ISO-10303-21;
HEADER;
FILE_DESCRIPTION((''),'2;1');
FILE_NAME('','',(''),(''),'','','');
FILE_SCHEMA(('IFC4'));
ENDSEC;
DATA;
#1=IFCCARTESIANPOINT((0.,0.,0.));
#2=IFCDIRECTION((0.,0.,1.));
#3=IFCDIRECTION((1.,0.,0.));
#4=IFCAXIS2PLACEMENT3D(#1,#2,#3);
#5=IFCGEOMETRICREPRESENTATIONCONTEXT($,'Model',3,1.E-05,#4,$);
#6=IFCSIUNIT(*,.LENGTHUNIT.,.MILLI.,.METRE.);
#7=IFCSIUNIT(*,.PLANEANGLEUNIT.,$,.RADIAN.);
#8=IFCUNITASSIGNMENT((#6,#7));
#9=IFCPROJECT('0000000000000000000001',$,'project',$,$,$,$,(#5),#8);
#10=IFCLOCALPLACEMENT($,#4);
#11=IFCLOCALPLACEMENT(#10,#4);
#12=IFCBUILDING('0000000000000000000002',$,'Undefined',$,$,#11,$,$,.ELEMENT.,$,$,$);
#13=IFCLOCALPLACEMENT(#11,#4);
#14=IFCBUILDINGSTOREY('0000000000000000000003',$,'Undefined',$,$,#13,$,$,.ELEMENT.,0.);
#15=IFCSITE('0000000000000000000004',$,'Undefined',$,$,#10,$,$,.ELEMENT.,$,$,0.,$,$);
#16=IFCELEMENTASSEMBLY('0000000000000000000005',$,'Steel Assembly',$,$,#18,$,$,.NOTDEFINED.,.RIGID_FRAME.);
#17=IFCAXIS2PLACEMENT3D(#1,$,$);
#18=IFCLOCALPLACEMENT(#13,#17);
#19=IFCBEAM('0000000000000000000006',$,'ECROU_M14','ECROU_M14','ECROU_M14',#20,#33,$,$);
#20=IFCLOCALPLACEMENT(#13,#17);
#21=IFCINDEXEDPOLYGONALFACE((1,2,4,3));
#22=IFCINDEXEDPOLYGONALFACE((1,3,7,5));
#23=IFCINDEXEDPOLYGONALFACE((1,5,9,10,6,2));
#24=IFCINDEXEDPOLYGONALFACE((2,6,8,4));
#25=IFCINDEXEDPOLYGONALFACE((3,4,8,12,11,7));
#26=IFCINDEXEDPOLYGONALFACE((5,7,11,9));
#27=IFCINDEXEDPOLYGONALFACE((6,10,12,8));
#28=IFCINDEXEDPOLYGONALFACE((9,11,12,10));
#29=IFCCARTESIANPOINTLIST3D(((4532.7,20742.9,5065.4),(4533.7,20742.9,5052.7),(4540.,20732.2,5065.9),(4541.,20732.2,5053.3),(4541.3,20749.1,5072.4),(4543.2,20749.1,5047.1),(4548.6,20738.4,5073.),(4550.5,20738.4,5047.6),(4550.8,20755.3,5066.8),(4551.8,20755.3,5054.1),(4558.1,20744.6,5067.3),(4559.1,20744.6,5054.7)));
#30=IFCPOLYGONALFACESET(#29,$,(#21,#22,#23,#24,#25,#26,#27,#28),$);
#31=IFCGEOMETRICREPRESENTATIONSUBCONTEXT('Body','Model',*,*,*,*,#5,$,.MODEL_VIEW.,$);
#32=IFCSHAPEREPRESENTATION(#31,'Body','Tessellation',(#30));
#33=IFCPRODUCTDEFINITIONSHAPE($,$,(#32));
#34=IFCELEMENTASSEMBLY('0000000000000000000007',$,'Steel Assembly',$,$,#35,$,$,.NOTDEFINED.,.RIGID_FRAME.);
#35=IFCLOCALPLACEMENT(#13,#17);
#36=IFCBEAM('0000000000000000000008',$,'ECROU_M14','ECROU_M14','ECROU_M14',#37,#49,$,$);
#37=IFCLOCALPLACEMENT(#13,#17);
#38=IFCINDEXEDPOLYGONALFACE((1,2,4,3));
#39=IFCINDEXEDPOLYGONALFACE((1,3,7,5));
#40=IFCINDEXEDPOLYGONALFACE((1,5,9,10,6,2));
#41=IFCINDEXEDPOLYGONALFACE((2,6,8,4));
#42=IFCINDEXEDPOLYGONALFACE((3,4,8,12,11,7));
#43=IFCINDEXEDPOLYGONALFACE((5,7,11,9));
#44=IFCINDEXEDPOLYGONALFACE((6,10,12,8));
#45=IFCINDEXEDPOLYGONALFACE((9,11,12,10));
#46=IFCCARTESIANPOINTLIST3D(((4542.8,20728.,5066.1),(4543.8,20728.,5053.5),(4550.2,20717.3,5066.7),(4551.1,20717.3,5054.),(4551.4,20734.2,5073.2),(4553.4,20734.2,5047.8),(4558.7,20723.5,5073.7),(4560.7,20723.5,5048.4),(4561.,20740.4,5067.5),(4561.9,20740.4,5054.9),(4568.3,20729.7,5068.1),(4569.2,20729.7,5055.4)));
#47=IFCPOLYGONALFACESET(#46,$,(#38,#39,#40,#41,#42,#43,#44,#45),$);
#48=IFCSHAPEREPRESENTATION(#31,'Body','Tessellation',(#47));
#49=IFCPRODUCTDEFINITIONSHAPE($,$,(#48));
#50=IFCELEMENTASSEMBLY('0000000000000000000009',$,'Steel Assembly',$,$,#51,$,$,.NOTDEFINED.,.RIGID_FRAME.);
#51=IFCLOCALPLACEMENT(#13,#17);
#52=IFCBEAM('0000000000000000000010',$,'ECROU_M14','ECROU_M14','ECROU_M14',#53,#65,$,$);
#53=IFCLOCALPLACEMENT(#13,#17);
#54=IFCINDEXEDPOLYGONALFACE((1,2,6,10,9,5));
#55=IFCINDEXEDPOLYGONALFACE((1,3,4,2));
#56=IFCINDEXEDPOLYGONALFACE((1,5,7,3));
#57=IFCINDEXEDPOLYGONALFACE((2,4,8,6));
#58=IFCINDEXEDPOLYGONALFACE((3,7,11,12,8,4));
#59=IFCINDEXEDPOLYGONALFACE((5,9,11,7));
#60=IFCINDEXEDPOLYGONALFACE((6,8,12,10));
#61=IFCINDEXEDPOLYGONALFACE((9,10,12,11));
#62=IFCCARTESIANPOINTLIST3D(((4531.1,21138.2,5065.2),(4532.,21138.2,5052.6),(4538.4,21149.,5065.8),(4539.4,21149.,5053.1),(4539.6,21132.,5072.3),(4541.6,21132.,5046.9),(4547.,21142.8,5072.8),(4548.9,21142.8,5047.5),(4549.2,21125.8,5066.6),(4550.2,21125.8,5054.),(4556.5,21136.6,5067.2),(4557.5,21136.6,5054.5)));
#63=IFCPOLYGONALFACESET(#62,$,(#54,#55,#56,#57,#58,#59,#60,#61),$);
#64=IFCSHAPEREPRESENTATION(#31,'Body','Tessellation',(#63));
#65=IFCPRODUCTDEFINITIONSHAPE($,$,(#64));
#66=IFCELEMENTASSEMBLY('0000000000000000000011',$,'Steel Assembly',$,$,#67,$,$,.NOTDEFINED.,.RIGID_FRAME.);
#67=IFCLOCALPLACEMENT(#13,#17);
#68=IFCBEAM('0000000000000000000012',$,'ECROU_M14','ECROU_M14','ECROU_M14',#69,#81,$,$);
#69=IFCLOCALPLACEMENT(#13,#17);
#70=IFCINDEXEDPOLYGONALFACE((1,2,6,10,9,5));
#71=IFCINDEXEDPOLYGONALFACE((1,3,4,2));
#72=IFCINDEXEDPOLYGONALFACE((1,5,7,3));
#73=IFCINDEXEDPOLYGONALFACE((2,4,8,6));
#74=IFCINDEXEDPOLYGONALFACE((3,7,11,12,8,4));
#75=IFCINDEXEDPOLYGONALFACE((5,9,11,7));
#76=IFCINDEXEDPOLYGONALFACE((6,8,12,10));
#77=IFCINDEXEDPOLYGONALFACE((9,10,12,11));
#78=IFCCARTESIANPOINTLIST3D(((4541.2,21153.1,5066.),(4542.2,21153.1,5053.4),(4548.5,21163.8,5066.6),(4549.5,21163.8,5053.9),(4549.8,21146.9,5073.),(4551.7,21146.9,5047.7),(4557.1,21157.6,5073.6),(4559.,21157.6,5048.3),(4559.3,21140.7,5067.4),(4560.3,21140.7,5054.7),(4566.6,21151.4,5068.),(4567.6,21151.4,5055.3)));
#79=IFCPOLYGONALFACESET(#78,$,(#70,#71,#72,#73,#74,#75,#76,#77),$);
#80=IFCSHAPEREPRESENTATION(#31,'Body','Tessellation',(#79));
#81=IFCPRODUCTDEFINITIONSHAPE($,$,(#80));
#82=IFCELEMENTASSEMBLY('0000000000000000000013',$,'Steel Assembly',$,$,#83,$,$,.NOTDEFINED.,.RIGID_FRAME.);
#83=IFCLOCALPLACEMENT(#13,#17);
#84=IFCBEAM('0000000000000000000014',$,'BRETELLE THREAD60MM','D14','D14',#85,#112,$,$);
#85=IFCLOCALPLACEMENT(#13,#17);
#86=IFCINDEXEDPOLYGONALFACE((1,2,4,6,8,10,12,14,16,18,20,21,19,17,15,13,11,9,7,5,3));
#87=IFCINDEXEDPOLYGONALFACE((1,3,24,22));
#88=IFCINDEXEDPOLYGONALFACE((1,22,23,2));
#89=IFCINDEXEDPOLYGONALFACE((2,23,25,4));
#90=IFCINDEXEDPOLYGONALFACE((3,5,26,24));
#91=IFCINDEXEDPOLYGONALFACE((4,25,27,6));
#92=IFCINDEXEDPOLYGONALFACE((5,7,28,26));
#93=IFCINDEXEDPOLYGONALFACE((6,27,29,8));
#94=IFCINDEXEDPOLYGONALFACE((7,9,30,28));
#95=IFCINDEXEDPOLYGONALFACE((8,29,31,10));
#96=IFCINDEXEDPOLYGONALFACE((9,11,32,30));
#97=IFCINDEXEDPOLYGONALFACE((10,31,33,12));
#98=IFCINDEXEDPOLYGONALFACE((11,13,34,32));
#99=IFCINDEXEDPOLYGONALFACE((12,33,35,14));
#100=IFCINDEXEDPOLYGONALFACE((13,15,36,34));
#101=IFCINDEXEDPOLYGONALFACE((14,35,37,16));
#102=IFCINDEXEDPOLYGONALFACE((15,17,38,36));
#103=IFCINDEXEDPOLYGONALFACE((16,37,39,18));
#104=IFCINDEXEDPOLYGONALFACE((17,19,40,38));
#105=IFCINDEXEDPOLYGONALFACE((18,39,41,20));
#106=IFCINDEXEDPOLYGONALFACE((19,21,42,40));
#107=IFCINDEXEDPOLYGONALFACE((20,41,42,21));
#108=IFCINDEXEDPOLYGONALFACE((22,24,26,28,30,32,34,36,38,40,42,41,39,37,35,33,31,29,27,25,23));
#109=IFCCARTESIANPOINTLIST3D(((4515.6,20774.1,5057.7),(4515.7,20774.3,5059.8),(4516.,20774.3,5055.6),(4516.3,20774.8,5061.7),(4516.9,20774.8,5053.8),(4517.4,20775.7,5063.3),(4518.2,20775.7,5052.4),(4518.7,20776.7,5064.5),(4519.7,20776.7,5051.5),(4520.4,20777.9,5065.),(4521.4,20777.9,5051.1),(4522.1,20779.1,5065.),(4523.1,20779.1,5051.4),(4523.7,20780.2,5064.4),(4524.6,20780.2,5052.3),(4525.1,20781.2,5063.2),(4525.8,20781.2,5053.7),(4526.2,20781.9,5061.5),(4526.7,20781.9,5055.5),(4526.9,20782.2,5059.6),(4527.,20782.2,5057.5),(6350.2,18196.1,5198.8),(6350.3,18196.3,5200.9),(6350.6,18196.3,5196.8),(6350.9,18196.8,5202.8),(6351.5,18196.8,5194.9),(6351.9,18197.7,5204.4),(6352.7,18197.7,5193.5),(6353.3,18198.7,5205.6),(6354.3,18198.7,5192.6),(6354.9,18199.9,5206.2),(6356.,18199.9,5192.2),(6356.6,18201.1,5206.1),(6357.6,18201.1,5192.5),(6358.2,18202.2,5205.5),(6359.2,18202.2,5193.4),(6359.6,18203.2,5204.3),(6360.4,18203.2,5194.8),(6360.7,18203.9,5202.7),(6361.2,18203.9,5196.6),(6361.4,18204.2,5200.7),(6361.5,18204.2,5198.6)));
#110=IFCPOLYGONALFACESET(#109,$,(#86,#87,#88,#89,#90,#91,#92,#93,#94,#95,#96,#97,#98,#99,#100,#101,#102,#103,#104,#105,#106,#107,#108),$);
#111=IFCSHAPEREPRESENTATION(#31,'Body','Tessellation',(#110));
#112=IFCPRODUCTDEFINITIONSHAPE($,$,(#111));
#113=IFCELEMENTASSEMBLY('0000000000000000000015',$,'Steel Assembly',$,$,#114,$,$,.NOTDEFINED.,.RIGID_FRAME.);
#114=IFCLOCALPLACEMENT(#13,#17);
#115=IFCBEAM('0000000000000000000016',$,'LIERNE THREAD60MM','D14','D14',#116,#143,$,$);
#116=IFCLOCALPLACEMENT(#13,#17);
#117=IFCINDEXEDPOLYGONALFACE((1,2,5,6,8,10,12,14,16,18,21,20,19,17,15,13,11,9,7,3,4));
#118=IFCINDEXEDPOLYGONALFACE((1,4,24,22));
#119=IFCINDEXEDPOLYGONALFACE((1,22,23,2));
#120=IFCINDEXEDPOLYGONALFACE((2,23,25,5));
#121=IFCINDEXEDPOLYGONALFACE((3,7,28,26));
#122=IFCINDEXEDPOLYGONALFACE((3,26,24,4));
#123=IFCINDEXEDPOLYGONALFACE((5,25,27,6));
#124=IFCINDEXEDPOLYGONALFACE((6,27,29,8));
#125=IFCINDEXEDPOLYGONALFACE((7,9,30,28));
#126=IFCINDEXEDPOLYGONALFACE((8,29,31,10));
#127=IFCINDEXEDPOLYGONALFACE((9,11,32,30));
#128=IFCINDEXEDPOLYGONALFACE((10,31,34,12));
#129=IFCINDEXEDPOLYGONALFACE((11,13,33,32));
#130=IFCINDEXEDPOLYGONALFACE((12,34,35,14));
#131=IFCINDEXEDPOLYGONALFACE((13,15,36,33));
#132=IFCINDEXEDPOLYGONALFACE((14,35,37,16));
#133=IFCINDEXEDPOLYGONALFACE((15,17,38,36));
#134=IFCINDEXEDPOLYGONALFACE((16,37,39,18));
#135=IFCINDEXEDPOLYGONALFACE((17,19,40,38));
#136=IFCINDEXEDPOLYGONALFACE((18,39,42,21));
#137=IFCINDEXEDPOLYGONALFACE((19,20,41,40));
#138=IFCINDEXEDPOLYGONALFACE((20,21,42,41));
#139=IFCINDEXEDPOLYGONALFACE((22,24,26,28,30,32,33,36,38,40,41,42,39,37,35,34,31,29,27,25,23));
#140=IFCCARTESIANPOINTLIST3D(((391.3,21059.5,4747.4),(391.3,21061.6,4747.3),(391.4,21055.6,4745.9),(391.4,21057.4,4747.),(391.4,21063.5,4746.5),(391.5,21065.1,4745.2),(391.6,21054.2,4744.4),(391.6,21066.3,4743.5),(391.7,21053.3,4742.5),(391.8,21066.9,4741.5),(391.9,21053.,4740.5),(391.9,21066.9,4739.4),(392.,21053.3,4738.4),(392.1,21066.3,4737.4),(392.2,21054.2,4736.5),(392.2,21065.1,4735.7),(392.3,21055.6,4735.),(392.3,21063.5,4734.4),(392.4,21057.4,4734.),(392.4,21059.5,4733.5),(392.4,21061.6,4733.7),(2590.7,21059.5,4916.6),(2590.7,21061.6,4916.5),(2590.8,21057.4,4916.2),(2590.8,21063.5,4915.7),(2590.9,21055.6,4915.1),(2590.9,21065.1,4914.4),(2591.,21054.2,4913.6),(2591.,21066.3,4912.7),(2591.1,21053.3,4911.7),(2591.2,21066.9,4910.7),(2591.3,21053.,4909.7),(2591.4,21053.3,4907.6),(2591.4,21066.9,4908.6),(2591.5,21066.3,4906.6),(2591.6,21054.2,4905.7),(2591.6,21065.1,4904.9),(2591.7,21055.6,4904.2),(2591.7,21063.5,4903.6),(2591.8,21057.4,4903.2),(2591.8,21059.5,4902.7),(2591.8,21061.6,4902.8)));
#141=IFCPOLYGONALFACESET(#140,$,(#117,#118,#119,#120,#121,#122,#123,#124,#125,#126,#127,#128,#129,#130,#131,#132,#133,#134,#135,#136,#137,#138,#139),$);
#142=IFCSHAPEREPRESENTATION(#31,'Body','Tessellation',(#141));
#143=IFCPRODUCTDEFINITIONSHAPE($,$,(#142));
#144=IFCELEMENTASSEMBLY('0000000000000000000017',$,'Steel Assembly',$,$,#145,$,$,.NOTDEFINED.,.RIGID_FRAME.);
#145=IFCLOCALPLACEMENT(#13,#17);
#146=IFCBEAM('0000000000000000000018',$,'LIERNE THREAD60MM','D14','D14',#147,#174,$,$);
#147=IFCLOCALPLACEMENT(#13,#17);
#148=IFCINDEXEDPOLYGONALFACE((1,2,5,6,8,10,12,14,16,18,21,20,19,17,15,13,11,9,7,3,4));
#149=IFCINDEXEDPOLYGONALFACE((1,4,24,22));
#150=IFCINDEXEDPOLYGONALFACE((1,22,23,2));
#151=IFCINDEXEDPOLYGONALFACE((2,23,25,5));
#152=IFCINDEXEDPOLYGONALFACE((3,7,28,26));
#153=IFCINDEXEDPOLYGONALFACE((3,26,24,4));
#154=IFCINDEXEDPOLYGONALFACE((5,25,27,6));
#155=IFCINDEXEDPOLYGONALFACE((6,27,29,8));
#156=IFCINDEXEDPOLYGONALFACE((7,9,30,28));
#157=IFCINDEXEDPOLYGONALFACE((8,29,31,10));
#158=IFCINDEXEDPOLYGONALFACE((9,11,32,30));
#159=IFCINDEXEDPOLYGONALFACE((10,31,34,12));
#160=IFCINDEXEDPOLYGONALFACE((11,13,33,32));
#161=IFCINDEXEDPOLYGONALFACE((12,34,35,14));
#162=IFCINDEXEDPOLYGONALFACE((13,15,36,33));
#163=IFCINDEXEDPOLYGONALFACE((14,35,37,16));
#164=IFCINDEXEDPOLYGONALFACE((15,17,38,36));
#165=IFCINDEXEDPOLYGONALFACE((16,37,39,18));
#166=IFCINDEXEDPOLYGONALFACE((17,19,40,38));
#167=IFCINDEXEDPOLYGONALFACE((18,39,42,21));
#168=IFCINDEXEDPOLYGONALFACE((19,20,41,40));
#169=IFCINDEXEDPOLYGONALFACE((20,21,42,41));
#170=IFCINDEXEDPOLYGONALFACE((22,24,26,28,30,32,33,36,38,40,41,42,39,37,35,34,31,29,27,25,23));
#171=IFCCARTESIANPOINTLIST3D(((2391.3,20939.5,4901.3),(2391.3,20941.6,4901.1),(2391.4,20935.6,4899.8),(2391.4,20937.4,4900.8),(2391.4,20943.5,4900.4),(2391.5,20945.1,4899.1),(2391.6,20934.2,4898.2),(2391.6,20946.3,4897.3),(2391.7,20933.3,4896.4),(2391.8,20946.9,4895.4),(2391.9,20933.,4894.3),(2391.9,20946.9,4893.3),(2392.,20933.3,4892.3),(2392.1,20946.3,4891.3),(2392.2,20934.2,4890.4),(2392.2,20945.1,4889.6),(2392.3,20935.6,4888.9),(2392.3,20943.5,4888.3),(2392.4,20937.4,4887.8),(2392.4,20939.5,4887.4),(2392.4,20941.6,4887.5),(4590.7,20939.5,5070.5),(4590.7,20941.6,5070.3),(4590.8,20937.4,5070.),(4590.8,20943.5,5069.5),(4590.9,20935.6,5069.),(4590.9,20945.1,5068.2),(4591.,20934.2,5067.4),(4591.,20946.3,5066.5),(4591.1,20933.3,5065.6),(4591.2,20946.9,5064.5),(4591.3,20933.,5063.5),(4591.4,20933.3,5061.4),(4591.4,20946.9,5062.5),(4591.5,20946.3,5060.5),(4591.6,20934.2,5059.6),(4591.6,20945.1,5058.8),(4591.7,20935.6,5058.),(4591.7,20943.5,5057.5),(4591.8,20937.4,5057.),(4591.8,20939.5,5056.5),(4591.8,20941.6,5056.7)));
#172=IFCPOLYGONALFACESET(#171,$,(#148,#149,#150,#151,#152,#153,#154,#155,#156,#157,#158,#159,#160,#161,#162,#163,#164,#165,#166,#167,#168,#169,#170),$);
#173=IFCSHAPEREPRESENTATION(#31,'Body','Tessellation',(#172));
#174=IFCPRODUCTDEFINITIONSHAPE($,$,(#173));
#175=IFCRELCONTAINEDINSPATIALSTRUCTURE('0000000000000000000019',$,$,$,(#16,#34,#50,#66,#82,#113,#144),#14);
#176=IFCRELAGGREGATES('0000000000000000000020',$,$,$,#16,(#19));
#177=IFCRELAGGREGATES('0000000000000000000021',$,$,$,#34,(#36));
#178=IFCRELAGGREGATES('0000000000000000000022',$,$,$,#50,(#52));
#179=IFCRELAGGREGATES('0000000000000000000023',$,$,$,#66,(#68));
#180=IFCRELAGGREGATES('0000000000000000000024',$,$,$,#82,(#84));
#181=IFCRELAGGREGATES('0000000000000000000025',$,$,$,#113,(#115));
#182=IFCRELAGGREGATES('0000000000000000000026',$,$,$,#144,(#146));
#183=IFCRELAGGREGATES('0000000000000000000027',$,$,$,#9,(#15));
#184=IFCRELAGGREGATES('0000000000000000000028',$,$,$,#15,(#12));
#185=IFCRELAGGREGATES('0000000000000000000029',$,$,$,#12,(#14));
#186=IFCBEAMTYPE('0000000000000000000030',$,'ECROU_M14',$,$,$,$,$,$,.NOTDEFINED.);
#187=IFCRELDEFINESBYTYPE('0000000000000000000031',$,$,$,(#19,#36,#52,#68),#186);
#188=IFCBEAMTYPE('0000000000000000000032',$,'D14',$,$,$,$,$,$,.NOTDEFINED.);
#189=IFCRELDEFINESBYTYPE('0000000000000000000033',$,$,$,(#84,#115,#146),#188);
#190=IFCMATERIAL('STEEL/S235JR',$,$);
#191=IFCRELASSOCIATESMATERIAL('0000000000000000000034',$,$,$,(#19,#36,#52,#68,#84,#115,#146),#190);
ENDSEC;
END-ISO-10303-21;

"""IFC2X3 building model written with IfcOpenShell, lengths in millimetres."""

from ifc_helpers import new_model, si_unit, frame, origin_with_axes, origin_2d_with_axis, place, context, subcontext, project, spatial, polyline, circle, outline, extrude, material, type_object, element, aggregate, save


model = new_model("IFC2X3")

# Units and contexts
model_context = context("Model", 3, precision=1e-05, world=origin_with_axes())
body_context = subcontext(model_context, "Body", "Model", "MODEL_VIEW")
ifc_project = project(units=[si_unit("LENGTHUNIT", "METRE", prefix="MILLI"), si_unit("PLANEANGLEUNIT", "RADIAN")], contexts=[model_context])

# Site, building, storey
site_placement = place(None, origin_with_axes())
site = spatial("IfcSite", under=ifc_project, at=site_placement, Name="Undefined", CompositionType="ELEMENT", RefElevation=0.0)
building_placement = place(site_placement, origin_with_axes())
building = spatial("IfcBuilding", under=site, at=building_placement, Name="Undefined", CompositionType="ELEMENT")
storey_placement = place(building_placement, origin_with_axes())
storey = spatial("IfcBuildingStorey", under=building, at=storey_placement, Name="Undefined", CompositionType="ELEMENT", Elevation=0.0)

# Element assemblies, beams
ifc_material_1 = material(Name="STEEL/S235JR")
beam_type_1 = type_object("IfcBeamType", Name="ECROU_M14", PredefinedType="NOTDEFINED")
assembly_1_placement = place(storey_placement, origin_with_axes())
assembly_1 = element("IfcElementAssembly", 1, at=assembly_1_placement, inside=storey, Name="Steel Assembly", AssemblyPlace="NOTDEFINED", PredefinedType="RIGID_FRAME")
beam_1_placement = place(assembly_1_placement, frame((4542.3, 20749.1, 5059.7), z_axis=(0.823335, 0.564012, 0.063333), x_axis=(0.56235, -0.825767, 0.043258)))
beam_1 = element("IfcBeam", 2, at=beam_1_placement, type_object=beam_type_1, material=ifc_material_1, Name="ECROU_M14", Description="ECROU_M14", ObjectType="ECROU_M14", context=body_context, shape_type="SweptSolid", body=[
    extrude(outline(polyline([(12.7, 0.0), (6.4, -11.0), (-6.4, -11.0), (-12.7, 0.0), (-6.4, 11.0), (6.4, 11.0), (12.7, 0.0)])), frame((13.0, 0.0, 0.0), z_axis=(-1.0, 0.0, 0.0), x_axis=(0.0, -1.0, 0.0)), (0.0, 0.0, 1.0), 13.0),
])
aggregate(assembly_1, [beam_1])
assembly_2_placement = place(storey_placement, origin_with_axes())
assembly_2 = element("IfcElementAssembly", 3, at=assembly_2_placement, inside=storey, Name="Steel Assembly", AssemblyPlace="NOTDEFINED", PredefinedType="RIGID_FRAME")
beam_2_placement = place(assembly_2_placement, frame((4552.4, 20734.2, 5060.5), z_axis=(0.823335, 0.564012, 0.063333), x_axis=(0.56235, -0.825767, 0.043258)))
beam_2 = element("IfcBeam", 4, at=beam_2_placement, type_object=beam_type_1, material=ifc_material_1, Name="ECROU_M14", Description="ECROU_M14", ObjectType="ECROU_M14", context=body_context, shape_type="SweptSolid", body=[
    extrude(outline(polyline([(12.7, 0.0), (6.4, -11.0), (-6.4, -11.0), (-12.7, 0.0), (-6.4, 11.0), (6.4, 11.0), (12.7, 0.0)])), frame((13.0, 0.0, 0.0), z_axis=(-1.0, 0.0, 0.0), x_axis=(0.0, -1.0, 0.0)), (0.0, 0.0, 1.0), 13.0),
])
aggregate(assembly_2, [beam_2])
assembly_3_placement = place(storey_placement, origin_with_axes())
assembly_3 = element("IfcElementAssembly", 5, at=assembly_3_placement, inside=storey, Name="Steel Assembly", AssemblyPlace="NOTDEFINED", PredefinedType="RIGID_FRAME")
beam_3_placement = place(assembly_3_placement, frame((4540.6, 21132.0, 5059.6), z_axis=(0.823335, -0.564012, 0.063333), x_axis=(0.56235, 0.825767, 0.043258)))
beam_3 = element("IfcBeam", 6, at=beam_3_placement, type_object=beam_type_1, material=ifc_material_1, Name="ECROU_M14", Description="ECROU_M14", ObjectType="ECROU_M14", context=body_context, shape_type="SweptSolid", body=[
    extrude(outline(polyline([(12.7, 0.0), (6.4, -11.0), (-6.4, -11.0), (-12.7, 0.0), (-6.4, 11.0), (6.4, 11.0), (12.7, 0.0)])), frame((13.0, 0.0, 0.0), z_axis=(-1.0, 0.0, 0.0), x_axis=(0.0, -1.0, 0.0)), (0.0, 0.0, 1.0), 13.0),
])
aggregate(assembly_3, [beam_3])
assembly_4_placement = place(storey_placement, origin_with_axes())
assembly_4 = element("IfcElementAssembly", 7, at=assembly_4_placement, inside=storey, Name="Steel Assembly", AssemblyPlace="NOTDEFINED", PredefinedType="RIGID_FRAME")
beam_4_placement = place(assembly_4_placement, frame((4550.7, 21146.9, 5060.4), z_axis=(0.823335, -0.564012, 0.063333), x_axis=(0.56235, 0.825767, 0.043258)))
beam_4 = element("IfcBeam", 8, at=beam_4_placement, type_object=beam_type_1, material=ifc_material_1, Name="ECROU_M14", Description="ECROU_M14", ObjectType="ECROU_M14", context=body_context, shape_type="SweptSolid", body=[
    extrude(outline(polyline([(12.7, 0.0), (6.4, -11.0), (-6.4, -11.0), (-12.7, 0.0), (-6.4, 11.0), (6.4, 11.0), (12.7, 0.0)])), frame((13.0, 0.0, 0.0), z_axis=(-1.0, 0.0, 0.0), x_axis=(0.0, -1.0, 0.0)), (0.0, 0.0, 1.0), 13.0),
])
aggregate(assembly_4, [beam_4])
assembly_5_placement = place(storey_placement, origin_with_axes())
assembly_5 = element("IfcElementAssembly", 9, at=assembly_5_placement, inside=storey, Name="Steel Assembly", AssemblyPlace="NOTDEFINED", PredefinedType="RIGID_FRAME")
beam_type_2 = type_object("IfcBeamType", Name="D14", PredefinedType="NOTDEFINED")
beam_5_placement = place(assembly_5_placement, frame((6355.8, 18200.2, 5199.2), z_axis=(0.076696, 0.0, -0.997054), x_axis=(-0.579218, 0.813954, -0.044555)))
beam_5 = element("IfcBeam", 10, at=beam_5_placement, type_object=beam_type_2, material=ifc_material_1, Name="BRETELLE THREAD60MM", Description="D14", ObjectType="D14", context=body_context, shape_type="SweptSolid", body=[
    extrude(circle(Radius=7.0, at=origin_2d_with_axis()), frame((3167.3, 0.0, 0.0), z_axis=(-1.0, 0.0, 0.0), x_axis=(0.0, -1.0, 0.0)), (0.0, 0.0, 1.0), 3167.2),
])
aggregate(assembly_5, [beam_5])
assembly_6_placement = place(storey_placement, origin_with_axes())
assembly_6 = element("IfcElementAssembly", 11, at=assembly_6_placement, inside=storey, Name="Steel Assembly", AssemblyPlace="NOTDEFINED", PredefinedType="RIGID_FRAME")
beam_6_placement = place(assembly_6_placement, frame((2591.3, 21060.0, 4909.7), z_axis=(0.076696, 0.0, -0.997054), x_axis=(-0.997054, 0.0, -0.076696)))
beam_6 = element("IfcBeam", 12, at=beam_6_placement, type_object=beam_type_2, material=ifc_material_1, Name="LIERNE THREAD60MM", Description="D14", ObjectType="D14", context=body_context, shape_type="SweptSolid", body=[
    extrude(circle(Radius=7.0, at=origin_2d_with_axis()), frame((2205.9, 0.0, 0.0), z_axis=(-1.0, 0.0, 0.0), x_axis=(0.0, -1.0, 0.0)), (0.0, 0.0, 1.0), 2205.9),
])
aggregate(assembly_6, [beam_6])
assembly_7_placement = place(storey_placement, origin_with_axes())
assembly_7 = element("IfcElementAssembly", 13, at=assembly_7_placement, inside=storey, Name="Steel Assembly", AssemblyPlace="NOTDEFINED", PredefinedType="RIGID_FRAME")
beam_7_placement = place(assembly_7_placement, frame((4591.3, 20940.0, 5063.5), z_axis=(0.076696, 0.0, -0.997054), x_axis=(-0.997054, 0.0, -0.076696)))
beam_7 = element("IfcBeam", 14, at=beam_7_placement, type_object=beam_type_2, material=ifc_material_1, Name="LIERNE THREAD60MM", Description="D14", ObjectType="D14", context=body_context, shape_type="SweptSolid", body=[
    extrude(circle(Radius=7.0, at=origin_2d_with_axis()), frame((2205.9, 0.0, 0.0), z_axis=(-1.0, 0.0, 0.0), x_axis=(0.0, -1.0, 0.0)), (0.0, 0.0, 1.0), 2205.9),
])
aggregate(assembly_7, [beam_7])

save(model, "model.ifc")
